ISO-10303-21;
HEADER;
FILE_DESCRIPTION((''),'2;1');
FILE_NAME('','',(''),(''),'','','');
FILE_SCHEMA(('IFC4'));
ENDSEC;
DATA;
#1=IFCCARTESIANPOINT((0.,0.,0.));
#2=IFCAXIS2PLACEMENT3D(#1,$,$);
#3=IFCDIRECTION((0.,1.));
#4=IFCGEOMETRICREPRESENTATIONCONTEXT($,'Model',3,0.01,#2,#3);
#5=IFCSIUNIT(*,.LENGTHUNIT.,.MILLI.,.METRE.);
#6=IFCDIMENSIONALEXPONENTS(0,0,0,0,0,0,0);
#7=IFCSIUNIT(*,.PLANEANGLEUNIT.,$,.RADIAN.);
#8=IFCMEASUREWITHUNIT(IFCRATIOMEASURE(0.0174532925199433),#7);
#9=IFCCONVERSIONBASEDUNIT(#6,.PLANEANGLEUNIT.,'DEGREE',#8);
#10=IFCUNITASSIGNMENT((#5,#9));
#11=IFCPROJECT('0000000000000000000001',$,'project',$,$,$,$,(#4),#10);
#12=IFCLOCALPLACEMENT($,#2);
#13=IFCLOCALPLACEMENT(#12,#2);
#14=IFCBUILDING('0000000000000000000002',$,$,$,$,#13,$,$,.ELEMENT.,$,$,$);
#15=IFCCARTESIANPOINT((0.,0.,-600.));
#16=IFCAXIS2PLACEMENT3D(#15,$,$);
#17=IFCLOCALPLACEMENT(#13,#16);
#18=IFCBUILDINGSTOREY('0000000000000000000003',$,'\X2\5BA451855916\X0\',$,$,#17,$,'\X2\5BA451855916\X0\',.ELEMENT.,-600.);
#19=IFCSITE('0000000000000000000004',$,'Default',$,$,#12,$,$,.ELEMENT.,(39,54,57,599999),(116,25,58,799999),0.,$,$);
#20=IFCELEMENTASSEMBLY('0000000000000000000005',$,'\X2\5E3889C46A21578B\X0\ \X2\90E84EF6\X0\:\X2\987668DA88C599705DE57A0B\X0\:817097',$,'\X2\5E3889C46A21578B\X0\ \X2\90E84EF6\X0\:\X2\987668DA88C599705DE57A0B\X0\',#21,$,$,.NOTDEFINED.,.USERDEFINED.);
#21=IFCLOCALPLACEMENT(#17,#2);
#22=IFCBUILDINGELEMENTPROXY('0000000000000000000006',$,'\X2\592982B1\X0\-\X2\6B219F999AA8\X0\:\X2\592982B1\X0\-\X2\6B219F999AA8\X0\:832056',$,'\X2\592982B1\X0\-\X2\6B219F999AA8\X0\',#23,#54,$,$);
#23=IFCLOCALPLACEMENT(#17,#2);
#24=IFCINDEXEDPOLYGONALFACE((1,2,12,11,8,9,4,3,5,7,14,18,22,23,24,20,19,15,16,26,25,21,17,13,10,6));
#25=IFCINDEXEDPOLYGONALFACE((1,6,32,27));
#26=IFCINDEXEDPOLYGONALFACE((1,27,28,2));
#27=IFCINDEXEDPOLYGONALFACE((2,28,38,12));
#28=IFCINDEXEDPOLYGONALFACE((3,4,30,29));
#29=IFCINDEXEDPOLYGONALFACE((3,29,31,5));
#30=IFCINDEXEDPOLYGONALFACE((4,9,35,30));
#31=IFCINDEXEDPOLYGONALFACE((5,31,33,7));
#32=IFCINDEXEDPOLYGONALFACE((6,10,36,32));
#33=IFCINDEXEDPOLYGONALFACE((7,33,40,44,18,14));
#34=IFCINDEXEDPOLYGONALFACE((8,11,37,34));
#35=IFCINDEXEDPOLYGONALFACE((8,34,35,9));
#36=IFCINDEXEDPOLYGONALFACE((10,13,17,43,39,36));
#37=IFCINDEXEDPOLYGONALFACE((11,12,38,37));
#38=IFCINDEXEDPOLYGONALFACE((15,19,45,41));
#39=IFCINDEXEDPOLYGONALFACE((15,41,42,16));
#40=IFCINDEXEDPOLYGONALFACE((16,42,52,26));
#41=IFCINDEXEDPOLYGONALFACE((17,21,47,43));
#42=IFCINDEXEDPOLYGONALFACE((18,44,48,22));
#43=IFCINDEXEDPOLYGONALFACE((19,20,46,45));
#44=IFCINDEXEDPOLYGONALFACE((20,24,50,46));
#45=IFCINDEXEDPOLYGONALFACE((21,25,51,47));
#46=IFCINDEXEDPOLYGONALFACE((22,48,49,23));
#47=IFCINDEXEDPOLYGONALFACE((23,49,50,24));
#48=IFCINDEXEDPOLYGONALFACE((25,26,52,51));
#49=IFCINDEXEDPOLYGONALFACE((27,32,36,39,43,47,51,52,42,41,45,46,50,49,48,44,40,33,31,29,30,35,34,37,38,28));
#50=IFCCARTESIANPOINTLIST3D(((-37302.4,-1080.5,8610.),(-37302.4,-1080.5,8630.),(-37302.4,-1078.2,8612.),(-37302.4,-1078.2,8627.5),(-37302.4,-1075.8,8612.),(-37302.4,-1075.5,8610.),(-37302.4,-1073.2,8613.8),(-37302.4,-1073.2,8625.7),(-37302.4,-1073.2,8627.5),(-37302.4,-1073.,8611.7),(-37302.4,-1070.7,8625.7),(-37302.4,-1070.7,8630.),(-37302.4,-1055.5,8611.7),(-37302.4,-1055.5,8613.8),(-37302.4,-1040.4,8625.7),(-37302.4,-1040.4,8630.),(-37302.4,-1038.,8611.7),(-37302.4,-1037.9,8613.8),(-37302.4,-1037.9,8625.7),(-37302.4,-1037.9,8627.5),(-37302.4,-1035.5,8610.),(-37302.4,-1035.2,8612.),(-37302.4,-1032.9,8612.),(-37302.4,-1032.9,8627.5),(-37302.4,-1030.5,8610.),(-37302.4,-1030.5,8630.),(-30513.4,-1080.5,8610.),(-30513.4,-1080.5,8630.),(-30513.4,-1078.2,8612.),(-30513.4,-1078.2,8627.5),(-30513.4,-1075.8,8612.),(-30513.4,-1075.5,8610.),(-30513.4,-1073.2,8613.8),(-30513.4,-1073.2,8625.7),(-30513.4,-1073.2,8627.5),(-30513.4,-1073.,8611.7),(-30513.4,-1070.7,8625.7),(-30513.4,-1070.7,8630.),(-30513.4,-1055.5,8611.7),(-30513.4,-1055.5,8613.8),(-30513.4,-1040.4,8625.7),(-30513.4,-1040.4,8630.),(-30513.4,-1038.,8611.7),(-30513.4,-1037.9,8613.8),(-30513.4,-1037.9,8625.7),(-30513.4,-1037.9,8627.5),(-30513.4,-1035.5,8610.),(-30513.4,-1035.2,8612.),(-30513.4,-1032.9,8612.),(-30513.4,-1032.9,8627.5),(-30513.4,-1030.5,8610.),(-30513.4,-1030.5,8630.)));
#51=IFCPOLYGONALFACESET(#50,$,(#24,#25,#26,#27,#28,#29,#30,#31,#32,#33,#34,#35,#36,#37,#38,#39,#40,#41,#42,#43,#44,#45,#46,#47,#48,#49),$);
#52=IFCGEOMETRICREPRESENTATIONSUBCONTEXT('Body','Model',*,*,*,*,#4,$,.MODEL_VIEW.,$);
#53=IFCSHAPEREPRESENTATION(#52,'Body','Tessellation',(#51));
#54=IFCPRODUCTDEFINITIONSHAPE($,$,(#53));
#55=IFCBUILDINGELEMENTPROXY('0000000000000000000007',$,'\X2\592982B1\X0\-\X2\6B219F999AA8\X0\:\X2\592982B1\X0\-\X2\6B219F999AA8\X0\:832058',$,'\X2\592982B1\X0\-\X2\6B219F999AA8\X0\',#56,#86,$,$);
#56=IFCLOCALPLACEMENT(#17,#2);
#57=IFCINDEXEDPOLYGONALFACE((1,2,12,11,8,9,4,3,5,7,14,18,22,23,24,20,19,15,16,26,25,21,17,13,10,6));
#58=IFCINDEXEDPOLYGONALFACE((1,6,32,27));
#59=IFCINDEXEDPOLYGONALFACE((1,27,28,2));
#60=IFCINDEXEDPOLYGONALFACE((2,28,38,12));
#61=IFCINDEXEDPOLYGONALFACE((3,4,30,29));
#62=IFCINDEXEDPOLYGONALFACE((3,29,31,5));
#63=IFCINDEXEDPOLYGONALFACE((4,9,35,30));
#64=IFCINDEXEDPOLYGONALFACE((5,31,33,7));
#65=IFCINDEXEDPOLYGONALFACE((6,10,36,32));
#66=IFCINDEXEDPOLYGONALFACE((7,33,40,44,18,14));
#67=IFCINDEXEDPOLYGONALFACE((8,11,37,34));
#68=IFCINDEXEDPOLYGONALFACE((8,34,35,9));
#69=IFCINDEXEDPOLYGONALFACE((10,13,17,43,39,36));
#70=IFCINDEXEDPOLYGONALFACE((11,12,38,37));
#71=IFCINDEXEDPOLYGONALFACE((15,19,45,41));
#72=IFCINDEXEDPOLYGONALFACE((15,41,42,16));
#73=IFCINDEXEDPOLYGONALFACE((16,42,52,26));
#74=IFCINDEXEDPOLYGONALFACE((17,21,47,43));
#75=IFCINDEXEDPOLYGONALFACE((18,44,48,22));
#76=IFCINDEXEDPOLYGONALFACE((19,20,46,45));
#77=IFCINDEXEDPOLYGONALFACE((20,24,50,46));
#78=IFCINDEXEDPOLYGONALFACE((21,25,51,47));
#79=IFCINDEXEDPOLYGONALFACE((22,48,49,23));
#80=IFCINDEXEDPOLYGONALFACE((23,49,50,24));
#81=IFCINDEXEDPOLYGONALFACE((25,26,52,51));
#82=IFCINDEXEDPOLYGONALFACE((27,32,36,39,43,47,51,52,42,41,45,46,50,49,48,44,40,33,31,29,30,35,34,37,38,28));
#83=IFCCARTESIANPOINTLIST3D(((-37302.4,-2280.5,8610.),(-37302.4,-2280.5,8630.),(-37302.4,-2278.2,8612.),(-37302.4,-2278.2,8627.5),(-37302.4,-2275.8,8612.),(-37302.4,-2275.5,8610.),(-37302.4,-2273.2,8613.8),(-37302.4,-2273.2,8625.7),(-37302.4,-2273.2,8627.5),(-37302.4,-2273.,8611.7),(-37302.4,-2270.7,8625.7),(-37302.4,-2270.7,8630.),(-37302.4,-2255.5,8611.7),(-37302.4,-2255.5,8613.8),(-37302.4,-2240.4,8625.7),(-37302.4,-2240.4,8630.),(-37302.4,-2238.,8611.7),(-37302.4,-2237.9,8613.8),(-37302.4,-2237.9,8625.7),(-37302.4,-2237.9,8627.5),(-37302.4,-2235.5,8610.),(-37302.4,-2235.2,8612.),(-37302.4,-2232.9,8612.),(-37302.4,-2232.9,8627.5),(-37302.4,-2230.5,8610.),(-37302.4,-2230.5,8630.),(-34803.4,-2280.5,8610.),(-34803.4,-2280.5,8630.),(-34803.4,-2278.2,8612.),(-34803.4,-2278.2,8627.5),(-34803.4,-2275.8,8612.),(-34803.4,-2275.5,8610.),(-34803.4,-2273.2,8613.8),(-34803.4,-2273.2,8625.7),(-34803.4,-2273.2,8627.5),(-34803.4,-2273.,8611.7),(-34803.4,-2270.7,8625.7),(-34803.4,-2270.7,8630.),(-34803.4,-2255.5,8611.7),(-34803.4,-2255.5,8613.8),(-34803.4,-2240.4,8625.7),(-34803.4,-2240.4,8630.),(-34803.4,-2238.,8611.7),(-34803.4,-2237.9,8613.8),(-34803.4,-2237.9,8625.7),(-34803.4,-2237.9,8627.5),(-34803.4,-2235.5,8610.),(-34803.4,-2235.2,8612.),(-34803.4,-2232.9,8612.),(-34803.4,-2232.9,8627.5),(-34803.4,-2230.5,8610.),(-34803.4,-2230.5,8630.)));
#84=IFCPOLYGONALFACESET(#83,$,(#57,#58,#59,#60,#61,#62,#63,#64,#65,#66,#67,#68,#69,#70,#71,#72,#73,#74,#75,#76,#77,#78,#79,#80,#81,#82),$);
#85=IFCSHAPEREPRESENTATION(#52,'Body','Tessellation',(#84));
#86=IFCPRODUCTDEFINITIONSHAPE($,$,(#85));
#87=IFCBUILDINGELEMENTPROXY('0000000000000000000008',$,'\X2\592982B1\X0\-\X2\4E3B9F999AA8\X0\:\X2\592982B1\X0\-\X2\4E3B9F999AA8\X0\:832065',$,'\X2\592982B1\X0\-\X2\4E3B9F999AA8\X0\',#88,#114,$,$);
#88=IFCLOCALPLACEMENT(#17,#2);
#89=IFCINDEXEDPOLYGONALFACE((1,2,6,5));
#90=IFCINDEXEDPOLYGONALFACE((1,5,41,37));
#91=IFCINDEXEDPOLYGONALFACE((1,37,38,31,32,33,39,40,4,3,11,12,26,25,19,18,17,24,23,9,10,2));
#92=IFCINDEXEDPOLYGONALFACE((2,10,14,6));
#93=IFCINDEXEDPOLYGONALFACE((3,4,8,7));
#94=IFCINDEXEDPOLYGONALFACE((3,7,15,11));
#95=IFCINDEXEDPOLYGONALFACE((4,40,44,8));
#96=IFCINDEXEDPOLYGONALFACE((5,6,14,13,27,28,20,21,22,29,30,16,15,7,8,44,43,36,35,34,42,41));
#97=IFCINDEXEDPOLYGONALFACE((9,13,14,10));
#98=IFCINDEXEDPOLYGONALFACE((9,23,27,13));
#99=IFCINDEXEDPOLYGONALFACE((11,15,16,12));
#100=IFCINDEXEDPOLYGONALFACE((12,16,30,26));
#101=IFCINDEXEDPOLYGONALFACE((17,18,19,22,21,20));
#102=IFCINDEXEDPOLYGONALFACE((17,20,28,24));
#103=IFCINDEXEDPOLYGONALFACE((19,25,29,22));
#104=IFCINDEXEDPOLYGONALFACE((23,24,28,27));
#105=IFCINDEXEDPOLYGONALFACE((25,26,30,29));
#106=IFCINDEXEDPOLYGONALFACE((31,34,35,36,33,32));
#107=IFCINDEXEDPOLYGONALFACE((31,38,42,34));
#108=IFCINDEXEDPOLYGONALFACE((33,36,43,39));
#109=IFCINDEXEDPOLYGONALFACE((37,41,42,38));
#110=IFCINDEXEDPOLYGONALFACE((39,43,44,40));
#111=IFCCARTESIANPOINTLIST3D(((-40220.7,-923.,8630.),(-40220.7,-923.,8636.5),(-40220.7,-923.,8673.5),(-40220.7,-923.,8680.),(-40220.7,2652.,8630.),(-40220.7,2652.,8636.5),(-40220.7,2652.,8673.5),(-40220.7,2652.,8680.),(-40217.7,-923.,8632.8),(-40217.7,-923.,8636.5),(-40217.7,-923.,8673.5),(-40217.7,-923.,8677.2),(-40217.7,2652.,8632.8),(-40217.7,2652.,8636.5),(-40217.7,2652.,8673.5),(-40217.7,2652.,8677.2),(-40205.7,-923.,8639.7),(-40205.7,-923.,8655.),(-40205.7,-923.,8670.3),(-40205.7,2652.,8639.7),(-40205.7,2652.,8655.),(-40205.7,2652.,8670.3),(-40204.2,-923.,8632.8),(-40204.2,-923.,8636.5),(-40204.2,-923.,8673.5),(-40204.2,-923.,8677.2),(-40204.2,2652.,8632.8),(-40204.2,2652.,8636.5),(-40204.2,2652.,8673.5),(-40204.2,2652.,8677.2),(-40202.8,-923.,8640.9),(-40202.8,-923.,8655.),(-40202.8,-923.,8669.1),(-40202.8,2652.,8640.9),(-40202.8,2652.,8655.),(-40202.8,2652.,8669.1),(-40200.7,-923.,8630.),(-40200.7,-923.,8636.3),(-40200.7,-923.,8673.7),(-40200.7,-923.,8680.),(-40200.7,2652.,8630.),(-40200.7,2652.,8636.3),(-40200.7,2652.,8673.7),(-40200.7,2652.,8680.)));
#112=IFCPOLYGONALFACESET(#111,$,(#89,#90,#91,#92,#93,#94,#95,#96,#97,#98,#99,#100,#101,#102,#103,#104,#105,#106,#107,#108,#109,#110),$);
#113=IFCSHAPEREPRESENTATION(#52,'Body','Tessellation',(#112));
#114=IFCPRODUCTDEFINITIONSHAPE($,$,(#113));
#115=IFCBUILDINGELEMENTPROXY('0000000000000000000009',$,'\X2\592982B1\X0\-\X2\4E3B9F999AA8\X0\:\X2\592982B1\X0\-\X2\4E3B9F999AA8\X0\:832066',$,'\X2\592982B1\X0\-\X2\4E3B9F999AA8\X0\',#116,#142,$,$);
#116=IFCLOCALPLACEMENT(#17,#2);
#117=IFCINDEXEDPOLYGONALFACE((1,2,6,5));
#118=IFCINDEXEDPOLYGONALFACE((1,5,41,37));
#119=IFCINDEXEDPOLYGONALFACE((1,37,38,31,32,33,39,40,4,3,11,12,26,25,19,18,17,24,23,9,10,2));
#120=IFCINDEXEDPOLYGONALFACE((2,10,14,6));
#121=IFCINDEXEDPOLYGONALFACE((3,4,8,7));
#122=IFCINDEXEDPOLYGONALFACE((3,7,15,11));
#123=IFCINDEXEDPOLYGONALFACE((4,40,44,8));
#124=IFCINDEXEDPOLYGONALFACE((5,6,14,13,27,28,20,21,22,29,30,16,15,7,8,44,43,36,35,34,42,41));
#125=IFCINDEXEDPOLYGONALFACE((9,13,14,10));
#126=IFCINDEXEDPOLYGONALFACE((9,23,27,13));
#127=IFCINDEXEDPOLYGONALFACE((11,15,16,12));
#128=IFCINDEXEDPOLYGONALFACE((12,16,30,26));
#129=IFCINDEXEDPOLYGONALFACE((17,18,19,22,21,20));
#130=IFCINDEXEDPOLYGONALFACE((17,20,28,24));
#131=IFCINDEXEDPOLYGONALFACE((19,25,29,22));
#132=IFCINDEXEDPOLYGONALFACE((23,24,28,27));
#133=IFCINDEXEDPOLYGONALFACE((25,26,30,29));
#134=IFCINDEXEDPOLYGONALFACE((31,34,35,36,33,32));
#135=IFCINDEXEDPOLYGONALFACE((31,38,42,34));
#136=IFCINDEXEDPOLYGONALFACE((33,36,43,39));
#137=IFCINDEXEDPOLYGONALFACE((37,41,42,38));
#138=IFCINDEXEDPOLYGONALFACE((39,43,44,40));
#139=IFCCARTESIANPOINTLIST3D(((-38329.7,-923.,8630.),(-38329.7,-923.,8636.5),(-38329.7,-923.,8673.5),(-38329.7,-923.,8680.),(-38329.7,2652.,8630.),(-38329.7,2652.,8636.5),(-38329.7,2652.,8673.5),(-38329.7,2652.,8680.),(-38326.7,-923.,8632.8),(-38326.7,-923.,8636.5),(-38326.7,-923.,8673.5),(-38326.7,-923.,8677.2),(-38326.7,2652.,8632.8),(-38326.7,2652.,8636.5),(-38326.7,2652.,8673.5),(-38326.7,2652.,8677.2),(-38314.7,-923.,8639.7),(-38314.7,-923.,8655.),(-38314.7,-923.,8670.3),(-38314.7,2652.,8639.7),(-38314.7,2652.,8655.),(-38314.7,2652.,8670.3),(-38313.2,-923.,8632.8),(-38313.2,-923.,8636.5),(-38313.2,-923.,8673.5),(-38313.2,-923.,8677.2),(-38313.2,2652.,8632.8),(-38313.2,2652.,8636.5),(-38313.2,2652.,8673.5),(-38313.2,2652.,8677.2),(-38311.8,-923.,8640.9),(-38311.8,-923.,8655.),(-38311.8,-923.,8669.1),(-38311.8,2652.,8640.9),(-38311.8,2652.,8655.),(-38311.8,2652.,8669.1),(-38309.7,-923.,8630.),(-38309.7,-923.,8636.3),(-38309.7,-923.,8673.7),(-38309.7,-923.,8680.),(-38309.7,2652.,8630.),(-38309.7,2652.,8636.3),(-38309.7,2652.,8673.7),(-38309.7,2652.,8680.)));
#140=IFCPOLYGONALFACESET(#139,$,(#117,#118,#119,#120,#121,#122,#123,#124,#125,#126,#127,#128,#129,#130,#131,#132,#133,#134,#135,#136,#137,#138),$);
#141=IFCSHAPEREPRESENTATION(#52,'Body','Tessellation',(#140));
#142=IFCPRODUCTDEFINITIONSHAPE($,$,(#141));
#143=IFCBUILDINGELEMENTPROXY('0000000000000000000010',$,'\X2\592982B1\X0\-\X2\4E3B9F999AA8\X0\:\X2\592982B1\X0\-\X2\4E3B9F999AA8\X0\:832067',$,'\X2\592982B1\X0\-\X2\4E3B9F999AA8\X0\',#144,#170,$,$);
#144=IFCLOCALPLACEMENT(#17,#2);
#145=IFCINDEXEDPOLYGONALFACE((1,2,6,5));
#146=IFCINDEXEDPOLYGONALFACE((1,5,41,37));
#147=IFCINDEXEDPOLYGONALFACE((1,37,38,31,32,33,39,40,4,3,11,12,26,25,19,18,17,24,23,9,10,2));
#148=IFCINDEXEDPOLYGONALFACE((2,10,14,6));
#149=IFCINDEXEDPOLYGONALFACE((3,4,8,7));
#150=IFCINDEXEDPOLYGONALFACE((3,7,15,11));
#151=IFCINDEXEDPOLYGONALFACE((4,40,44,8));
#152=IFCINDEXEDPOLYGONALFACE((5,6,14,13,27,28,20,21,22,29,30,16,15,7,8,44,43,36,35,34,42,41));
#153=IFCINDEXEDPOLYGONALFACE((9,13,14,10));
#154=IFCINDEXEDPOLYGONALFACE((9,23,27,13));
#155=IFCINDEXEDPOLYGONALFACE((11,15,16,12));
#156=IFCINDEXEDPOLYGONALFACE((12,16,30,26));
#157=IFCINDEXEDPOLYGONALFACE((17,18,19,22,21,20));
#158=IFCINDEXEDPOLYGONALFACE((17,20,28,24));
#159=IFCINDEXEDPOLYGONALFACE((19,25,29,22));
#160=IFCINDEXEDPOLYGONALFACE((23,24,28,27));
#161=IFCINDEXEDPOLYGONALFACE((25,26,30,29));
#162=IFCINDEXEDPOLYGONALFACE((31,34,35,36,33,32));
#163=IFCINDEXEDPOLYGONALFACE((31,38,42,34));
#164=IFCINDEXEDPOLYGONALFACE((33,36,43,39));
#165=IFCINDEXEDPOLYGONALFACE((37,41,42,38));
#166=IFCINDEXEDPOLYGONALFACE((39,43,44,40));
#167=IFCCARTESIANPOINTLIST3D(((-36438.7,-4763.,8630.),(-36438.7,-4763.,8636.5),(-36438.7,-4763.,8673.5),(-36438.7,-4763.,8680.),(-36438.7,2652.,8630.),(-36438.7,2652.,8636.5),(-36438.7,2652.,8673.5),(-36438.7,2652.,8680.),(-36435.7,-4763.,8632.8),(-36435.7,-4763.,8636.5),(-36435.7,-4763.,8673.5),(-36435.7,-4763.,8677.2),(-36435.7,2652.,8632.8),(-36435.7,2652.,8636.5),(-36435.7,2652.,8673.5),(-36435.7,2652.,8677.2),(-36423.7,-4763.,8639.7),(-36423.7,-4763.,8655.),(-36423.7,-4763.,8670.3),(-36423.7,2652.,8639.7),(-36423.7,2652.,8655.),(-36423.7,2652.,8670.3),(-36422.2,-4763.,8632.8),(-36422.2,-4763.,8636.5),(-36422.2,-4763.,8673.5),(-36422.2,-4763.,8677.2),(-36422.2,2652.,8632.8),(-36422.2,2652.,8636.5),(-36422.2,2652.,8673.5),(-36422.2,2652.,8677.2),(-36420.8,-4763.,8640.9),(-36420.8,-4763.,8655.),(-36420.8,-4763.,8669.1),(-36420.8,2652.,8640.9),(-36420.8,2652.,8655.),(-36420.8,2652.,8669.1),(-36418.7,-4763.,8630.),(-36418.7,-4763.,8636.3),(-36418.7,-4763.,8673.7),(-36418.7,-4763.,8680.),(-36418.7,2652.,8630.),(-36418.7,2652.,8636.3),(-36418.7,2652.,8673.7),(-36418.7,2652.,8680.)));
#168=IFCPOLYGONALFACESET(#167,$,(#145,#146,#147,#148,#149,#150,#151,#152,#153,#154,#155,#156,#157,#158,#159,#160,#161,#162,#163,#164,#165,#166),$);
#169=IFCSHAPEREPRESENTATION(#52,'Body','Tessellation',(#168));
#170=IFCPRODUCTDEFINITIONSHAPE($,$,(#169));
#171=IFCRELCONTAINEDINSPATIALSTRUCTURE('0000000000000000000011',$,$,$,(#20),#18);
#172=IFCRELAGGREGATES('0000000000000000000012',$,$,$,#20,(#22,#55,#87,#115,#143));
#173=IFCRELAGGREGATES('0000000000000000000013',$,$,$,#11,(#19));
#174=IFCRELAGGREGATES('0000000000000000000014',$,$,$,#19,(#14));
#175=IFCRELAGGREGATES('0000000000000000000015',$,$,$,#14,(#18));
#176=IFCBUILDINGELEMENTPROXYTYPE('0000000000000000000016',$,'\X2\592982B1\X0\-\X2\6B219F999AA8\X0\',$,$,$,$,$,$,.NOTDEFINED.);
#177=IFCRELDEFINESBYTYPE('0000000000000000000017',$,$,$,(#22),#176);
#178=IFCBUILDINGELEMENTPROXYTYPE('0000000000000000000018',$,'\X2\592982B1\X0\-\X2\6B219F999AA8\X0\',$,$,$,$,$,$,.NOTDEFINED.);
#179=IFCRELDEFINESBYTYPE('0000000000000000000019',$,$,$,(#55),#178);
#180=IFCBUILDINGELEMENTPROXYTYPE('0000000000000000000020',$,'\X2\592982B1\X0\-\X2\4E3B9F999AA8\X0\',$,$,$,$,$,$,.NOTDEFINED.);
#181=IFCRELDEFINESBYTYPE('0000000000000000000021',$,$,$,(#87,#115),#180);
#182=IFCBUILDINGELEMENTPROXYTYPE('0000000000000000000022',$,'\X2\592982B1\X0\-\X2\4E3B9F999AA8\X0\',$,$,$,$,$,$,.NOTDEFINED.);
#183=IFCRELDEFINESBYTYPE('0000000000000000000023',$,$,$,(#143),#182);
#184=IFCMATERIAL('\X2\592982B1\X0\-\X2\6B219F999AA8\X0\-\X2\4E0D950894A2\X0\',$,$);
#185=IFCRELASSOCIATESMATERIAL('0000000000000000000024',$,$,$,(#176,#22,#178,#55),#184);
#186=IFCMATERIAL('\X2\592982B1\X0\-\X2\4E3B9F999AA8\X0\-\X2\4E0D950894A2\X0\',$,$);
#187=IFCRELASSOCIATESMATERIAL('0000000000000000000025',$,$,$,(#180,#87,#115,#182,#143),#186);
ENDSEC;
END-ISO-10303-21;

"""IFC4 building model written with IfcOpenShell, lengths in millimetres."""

from ifc_helpers import new_model, entity, si_unit, converted_unit, direction, frame, origin, place, context, subcontext, project, spatial, polyline, outline, extrude, source, transform, mapped, material, type_object, type_shapes, element, aggregate, save


model = new_model("IFC4")

# Units and contexts
model_context = context("Model", 3, precision=0.01, world=origin(), true_north=direction((0.0, 1.0)))
body_context = subcontext(model_context, "Body", "Model", "MODEL_VIEW")
ifc_project = project(units=[si_unit("LENGTHUNIT", "METRE", prefix="MILLI"), converted_unit("PLANEANGLEUNIT", "DEGREE", entity("IfcRatioMeasure", 0.0174532925199433), si_unit("PLANEANGLEUNIT", "RADIAN"), dimensions=[0, 0, 0, 0, 0, 0, 0])], contexts=[model_context])

# Site, building, storey
site_placement = place(None, origin())
site = spatial("IfcSite", under=ifc_project, at=site_placement, Name="Default", CompositionType="ELEMENT", RefLatitude=(39, 54, 57, 599999), RefLongitude=(116, 25, 58, 799999), RefElevation=0.0)
building_placement = place(site_placement, origin())
building = spatial("IfcBuilding", under=site, at=building_placement, CompositionType="ELEMENT")
storey_placement = place(building_placement, frame((0.0, 0.0, -600.0)))
storey = spatial("IfcBuildingStorey", under=building, at=storey_placement, Name="室内外", LongName="室内外", CompositionType="ELEMENT", Elevation=-600.0)

# Element assembly
assembly_1_placement = place(storey_placement, origin())
assembly_1 = element("IfcElementAssembly", 1, at=assembly_1_placement, inside=storey, Name="常规模型 部件:顶棚装饰工程:817097", ObjectType="常规模型 部件:顶棚装饰工程", AssemblyPlace="NOTDEFINED", PredefinedType="USERDEFINED")

# Building element proxies
ifc_material_1 = material(Name="天花-次龙骨-不锈钢")
building_element_proxy_type_1 = type_object("IfcBuildingElementProxyType", Name="天花-次龙骨", PredefinedType="NOTDEFINED", material=ifc_material_1)
shared_shape_1 = source(origin(), body_context, "Body", "SweptSolid", [
    extrude(outline(polyline([(-25.0, -9.1), (-20.0, -9.1), (-17.5, -7.4), (0.0, -7.4), (17.5, -7.4), (20.0, -9.1), (25.0, -9.1), (25.0, 10.9), (15.1, 10.9), (15.1, 6.6), (17.6, 6.6), (17.6, 8.4), (22.6, 8.4), (22.6, -7.1), (20.3, -7.1), (17.6, -5.3), (0.0, -5.3), (-17.6, -5.3), (-20.3, -7.1), (-22.6, -7.1), (-22.6, 8.4), (-17.6, 8.4), (-17.6, 6.6), (-15.1, 6.6), (-15.1, 10.9), (-25.0, 10.9), (-25.0, -9.1)])), frame((0.0, 0.0, -0.9), z_axis=(1.0, 0.0, 0.0), x_axis=(0.0, 1.0, 0.0)), (0.0, 0.0, 1.0), 6789.0),
])
type_shapes(building_element_proxy_type_1, [shared_shape_1])
proxy_1_placement = place(assembly_1_placement, frame((-37302.4, -1055.5, 8620.0)))
proxy_1 = element("IfcBuildingElementProxy", 2, at=proxy_1_placement, type_object=building_element_proxy_type_1, material=ifc_material_1, Name="天花-次龙骨:天花-次龙骨:832056", ObjectType="天花-次龙骨", context=body_context, shape_type="MappedRepresentation", body=[
    mapped(shared_shape_1, transform((0.0, 0.0, 0.0), scale=1.0)),
])
building_element_proxy_type_2 = type_object("IfcBuildingElementProxyType", Name="天花-次龙骨", PredefinedType="NOTDEFINED", material=ifc_material_1)
shared_shape_2 = source(origin(), body_context, "Body", "SweptSolid", [
    extrude(outline(polyline([(-25.0, -9.1), (-20.0, -9.1), (-17.5, -7.4), (0.0, -7.4), (17.5, -7.4), (20.0, -9.1), (25.0, -9.1), (25.0, 10.9), (15.1, 10.9), (15.1, 6.6), (17.6, 6.6), (17.6, 8.4), (22.6, 8.4), (22.6, -7.1), (20.3, -7.1), (17.6, -5.3), (0.0, -5.3), (-17.6, -5.3), (-20.3, -7.1), (-22.6, -7.1), (-22.6, 8.4), (-17.6, 8.4), (-17.6, 6.6), (-15.1, 6.6), (-15.1, 10.9), (-25.0, 10.9), (-25.0, -9.1)])), frame((0.0, 0.0, -0.9), z_axis=(1.0, 0.0, 0.0), x_axis=(0.0, 1.0, 0.0)), (0.0, 0.0, 1.0), 2499.0),
])
type_shapes(building_element_proxy_type_2, [shared_shape_2])
proxy_2_placement = place(assembly_1_placement, frame((-37302.4, -2255.5, 8620.0)))
proxy_2 = element("IfcBuildingElementProxy", 3, at=proxy_2_placement, type_object=building_element_proxy_type_2, material=ifc_material_1, Name="天花-次龙骨:天花-次龙骨:832058", ObjectType="天花-次龙骨", context=body_context, shape_type="MappedRepresentation", body=[
    mapped(shared_shape_2, transform((0.0, 0.0, 0.0), scale=1.0)),
])
ifc_material_2 = material(Name="天花-主龙骨-不锈钢")
building_element_proxy_type_3 = type_object("IfcBuildingElementProxyType", Name="天花-主龙骨", PredefinedType="NOTDEFINED", material=ifc_material_2)
shared_shape_3 = source(origin(), body_context, "Body", "SweptSolid", [
    extrude(outline(polyline([(-25.0, -11.7), (-18.5, -11.7), (-18.5, -8.7), (-22.2, -8.7), (-22.2, 4.8), (-18.5, 4.8), (-15.3, 3.3), (0.0, 3.3), (15.3, 3.3), (18.5, 4.8), (22.2, 4.8), (22.2, -8.7), (18.5, -8.7), (18.5, -11.7), (25.0, -11.7), (25.0, 8.3), (18.7, 8.3), (14.1, 6.2), (0.0, 6.2), (-14.1, 6.2), (-18.7, 8.3), (-25.0, 8.3), (-25.0, -11.7)])), frame((0.0, 1.7, 0.0), z_axis=(1.0, 0.0, 0.0), x_axis=(0.0, 0.0, -1.0)), (0.0, 0.0, 1.0), 3575.0),
])
type_shapes(building_element_proxy_type_3, [shared_shape_3])
proxy_3_placement = place(assembly_1_placement, frame((-40210.7, 2652.0, 8655.0), z_axis=(0.0, 0.0, 1.0), x_axis=(0.0, -1.0, 0.0)))
proxy_3 = element("IfcBuildingElementProxy", 4, at=proxy_3_placement, type_object=building_element_proxy_type_3, material=ifc_material_2, Name="天花-主龙骨:天花-主龙骨:832065", ObjectType="天花-主龙骨", context=body_context, shape_type="MappedRepresentation", body=[
    mapped(shared_shape_3, transform((0.0, 0.0, 0.0), scale=1.0)),
])
proxy_4_placement = place(assembly_1_placement, frame((-38319.7, 2652.0, 8655.0), z_axis=(0.0, 0.0, 1.0), x_axis=(0.0, -1.0, 0.0)))
proxy_4 = element("IfcBuildingElementProxy", 5, at=proxy_4_placement, type_object=building_element_proxy_type_3, material=ifc_material_2, Name="天花-主龙骨:天花-主龙骨:832066", ObjectType="天花-主龙骨", context=body_context, shape_type="MappedRepresentation", body=[
    mapped(shared_shape_3, transform((0.0, 0.0, 0.0), scale=1.0)),
])
building_element_proxy_type_4 = type_object("IfcBuildingElementProxyType", Name="天花-主龙骨", PredefinedType="NOTDEFINED", material=ifc_material_2)
shared_shape_4 = source(origin(), body_context, "Body", "SweptSolid", [
    extrude(outline(polyline([(-25.0, -11.7), (-18.5, -11.7), (-18.5, -8.7), (-22.2, -8.7), (-22.2, 4.8), (-18.5, 4.8), (-15.3, 3.3), (0.0, 3.3), (15.3, 3.3), (18.5, 4.8), (22.2, 4.8), (22.2, -8.7), (18.5, -8.7), (18.5, -11.7), (25.0, -11.7), (25.0, 8.3), (18.7, 8.3), (14.1, 6.2), (0.0, 6.2), (-14.1, 6.2), (-18.7, 8.3), (-25.0, 8.3), (-25.0, -11.7)])), frame((0.0, 1.7, 0.0), z_axis=(1.0, 0.0, 0.0), x_axis=(0.0, 0.0, -1.0)), (0.0, 0.0, 1.0), 7415.0),
])
type_shapes(building_element_proxy_type_4, [shared_shape_4])
proxy_5_placement = place(assembly_1_placement, frame((-36428.7, 2652.0, 8655.0), z_axis=(0.0, 0.0, 1.0), x_axis=(0.0, -1.0, 0.0)))
proxy_5 = element("IfcBuildingElementProxy", 6, at=proxy_5_placement, type_object=building_element_proxy_type_4, material=ifc_material_2, Name="天花-主龙骨:天花-主龙骨:832067", ObjectType="天花-主龙骨", context=body_context, shape_type="MappedRepresentation", body=[
    mapped(shared_shape_4, transform((0.0, 0.0, 0.0), scale=1.0)),
])
aggregate(assembly_1, [proxy_1, proxy_2, proxy_3, proxy_4, proxy_5])

save(model, "model.ifc")
